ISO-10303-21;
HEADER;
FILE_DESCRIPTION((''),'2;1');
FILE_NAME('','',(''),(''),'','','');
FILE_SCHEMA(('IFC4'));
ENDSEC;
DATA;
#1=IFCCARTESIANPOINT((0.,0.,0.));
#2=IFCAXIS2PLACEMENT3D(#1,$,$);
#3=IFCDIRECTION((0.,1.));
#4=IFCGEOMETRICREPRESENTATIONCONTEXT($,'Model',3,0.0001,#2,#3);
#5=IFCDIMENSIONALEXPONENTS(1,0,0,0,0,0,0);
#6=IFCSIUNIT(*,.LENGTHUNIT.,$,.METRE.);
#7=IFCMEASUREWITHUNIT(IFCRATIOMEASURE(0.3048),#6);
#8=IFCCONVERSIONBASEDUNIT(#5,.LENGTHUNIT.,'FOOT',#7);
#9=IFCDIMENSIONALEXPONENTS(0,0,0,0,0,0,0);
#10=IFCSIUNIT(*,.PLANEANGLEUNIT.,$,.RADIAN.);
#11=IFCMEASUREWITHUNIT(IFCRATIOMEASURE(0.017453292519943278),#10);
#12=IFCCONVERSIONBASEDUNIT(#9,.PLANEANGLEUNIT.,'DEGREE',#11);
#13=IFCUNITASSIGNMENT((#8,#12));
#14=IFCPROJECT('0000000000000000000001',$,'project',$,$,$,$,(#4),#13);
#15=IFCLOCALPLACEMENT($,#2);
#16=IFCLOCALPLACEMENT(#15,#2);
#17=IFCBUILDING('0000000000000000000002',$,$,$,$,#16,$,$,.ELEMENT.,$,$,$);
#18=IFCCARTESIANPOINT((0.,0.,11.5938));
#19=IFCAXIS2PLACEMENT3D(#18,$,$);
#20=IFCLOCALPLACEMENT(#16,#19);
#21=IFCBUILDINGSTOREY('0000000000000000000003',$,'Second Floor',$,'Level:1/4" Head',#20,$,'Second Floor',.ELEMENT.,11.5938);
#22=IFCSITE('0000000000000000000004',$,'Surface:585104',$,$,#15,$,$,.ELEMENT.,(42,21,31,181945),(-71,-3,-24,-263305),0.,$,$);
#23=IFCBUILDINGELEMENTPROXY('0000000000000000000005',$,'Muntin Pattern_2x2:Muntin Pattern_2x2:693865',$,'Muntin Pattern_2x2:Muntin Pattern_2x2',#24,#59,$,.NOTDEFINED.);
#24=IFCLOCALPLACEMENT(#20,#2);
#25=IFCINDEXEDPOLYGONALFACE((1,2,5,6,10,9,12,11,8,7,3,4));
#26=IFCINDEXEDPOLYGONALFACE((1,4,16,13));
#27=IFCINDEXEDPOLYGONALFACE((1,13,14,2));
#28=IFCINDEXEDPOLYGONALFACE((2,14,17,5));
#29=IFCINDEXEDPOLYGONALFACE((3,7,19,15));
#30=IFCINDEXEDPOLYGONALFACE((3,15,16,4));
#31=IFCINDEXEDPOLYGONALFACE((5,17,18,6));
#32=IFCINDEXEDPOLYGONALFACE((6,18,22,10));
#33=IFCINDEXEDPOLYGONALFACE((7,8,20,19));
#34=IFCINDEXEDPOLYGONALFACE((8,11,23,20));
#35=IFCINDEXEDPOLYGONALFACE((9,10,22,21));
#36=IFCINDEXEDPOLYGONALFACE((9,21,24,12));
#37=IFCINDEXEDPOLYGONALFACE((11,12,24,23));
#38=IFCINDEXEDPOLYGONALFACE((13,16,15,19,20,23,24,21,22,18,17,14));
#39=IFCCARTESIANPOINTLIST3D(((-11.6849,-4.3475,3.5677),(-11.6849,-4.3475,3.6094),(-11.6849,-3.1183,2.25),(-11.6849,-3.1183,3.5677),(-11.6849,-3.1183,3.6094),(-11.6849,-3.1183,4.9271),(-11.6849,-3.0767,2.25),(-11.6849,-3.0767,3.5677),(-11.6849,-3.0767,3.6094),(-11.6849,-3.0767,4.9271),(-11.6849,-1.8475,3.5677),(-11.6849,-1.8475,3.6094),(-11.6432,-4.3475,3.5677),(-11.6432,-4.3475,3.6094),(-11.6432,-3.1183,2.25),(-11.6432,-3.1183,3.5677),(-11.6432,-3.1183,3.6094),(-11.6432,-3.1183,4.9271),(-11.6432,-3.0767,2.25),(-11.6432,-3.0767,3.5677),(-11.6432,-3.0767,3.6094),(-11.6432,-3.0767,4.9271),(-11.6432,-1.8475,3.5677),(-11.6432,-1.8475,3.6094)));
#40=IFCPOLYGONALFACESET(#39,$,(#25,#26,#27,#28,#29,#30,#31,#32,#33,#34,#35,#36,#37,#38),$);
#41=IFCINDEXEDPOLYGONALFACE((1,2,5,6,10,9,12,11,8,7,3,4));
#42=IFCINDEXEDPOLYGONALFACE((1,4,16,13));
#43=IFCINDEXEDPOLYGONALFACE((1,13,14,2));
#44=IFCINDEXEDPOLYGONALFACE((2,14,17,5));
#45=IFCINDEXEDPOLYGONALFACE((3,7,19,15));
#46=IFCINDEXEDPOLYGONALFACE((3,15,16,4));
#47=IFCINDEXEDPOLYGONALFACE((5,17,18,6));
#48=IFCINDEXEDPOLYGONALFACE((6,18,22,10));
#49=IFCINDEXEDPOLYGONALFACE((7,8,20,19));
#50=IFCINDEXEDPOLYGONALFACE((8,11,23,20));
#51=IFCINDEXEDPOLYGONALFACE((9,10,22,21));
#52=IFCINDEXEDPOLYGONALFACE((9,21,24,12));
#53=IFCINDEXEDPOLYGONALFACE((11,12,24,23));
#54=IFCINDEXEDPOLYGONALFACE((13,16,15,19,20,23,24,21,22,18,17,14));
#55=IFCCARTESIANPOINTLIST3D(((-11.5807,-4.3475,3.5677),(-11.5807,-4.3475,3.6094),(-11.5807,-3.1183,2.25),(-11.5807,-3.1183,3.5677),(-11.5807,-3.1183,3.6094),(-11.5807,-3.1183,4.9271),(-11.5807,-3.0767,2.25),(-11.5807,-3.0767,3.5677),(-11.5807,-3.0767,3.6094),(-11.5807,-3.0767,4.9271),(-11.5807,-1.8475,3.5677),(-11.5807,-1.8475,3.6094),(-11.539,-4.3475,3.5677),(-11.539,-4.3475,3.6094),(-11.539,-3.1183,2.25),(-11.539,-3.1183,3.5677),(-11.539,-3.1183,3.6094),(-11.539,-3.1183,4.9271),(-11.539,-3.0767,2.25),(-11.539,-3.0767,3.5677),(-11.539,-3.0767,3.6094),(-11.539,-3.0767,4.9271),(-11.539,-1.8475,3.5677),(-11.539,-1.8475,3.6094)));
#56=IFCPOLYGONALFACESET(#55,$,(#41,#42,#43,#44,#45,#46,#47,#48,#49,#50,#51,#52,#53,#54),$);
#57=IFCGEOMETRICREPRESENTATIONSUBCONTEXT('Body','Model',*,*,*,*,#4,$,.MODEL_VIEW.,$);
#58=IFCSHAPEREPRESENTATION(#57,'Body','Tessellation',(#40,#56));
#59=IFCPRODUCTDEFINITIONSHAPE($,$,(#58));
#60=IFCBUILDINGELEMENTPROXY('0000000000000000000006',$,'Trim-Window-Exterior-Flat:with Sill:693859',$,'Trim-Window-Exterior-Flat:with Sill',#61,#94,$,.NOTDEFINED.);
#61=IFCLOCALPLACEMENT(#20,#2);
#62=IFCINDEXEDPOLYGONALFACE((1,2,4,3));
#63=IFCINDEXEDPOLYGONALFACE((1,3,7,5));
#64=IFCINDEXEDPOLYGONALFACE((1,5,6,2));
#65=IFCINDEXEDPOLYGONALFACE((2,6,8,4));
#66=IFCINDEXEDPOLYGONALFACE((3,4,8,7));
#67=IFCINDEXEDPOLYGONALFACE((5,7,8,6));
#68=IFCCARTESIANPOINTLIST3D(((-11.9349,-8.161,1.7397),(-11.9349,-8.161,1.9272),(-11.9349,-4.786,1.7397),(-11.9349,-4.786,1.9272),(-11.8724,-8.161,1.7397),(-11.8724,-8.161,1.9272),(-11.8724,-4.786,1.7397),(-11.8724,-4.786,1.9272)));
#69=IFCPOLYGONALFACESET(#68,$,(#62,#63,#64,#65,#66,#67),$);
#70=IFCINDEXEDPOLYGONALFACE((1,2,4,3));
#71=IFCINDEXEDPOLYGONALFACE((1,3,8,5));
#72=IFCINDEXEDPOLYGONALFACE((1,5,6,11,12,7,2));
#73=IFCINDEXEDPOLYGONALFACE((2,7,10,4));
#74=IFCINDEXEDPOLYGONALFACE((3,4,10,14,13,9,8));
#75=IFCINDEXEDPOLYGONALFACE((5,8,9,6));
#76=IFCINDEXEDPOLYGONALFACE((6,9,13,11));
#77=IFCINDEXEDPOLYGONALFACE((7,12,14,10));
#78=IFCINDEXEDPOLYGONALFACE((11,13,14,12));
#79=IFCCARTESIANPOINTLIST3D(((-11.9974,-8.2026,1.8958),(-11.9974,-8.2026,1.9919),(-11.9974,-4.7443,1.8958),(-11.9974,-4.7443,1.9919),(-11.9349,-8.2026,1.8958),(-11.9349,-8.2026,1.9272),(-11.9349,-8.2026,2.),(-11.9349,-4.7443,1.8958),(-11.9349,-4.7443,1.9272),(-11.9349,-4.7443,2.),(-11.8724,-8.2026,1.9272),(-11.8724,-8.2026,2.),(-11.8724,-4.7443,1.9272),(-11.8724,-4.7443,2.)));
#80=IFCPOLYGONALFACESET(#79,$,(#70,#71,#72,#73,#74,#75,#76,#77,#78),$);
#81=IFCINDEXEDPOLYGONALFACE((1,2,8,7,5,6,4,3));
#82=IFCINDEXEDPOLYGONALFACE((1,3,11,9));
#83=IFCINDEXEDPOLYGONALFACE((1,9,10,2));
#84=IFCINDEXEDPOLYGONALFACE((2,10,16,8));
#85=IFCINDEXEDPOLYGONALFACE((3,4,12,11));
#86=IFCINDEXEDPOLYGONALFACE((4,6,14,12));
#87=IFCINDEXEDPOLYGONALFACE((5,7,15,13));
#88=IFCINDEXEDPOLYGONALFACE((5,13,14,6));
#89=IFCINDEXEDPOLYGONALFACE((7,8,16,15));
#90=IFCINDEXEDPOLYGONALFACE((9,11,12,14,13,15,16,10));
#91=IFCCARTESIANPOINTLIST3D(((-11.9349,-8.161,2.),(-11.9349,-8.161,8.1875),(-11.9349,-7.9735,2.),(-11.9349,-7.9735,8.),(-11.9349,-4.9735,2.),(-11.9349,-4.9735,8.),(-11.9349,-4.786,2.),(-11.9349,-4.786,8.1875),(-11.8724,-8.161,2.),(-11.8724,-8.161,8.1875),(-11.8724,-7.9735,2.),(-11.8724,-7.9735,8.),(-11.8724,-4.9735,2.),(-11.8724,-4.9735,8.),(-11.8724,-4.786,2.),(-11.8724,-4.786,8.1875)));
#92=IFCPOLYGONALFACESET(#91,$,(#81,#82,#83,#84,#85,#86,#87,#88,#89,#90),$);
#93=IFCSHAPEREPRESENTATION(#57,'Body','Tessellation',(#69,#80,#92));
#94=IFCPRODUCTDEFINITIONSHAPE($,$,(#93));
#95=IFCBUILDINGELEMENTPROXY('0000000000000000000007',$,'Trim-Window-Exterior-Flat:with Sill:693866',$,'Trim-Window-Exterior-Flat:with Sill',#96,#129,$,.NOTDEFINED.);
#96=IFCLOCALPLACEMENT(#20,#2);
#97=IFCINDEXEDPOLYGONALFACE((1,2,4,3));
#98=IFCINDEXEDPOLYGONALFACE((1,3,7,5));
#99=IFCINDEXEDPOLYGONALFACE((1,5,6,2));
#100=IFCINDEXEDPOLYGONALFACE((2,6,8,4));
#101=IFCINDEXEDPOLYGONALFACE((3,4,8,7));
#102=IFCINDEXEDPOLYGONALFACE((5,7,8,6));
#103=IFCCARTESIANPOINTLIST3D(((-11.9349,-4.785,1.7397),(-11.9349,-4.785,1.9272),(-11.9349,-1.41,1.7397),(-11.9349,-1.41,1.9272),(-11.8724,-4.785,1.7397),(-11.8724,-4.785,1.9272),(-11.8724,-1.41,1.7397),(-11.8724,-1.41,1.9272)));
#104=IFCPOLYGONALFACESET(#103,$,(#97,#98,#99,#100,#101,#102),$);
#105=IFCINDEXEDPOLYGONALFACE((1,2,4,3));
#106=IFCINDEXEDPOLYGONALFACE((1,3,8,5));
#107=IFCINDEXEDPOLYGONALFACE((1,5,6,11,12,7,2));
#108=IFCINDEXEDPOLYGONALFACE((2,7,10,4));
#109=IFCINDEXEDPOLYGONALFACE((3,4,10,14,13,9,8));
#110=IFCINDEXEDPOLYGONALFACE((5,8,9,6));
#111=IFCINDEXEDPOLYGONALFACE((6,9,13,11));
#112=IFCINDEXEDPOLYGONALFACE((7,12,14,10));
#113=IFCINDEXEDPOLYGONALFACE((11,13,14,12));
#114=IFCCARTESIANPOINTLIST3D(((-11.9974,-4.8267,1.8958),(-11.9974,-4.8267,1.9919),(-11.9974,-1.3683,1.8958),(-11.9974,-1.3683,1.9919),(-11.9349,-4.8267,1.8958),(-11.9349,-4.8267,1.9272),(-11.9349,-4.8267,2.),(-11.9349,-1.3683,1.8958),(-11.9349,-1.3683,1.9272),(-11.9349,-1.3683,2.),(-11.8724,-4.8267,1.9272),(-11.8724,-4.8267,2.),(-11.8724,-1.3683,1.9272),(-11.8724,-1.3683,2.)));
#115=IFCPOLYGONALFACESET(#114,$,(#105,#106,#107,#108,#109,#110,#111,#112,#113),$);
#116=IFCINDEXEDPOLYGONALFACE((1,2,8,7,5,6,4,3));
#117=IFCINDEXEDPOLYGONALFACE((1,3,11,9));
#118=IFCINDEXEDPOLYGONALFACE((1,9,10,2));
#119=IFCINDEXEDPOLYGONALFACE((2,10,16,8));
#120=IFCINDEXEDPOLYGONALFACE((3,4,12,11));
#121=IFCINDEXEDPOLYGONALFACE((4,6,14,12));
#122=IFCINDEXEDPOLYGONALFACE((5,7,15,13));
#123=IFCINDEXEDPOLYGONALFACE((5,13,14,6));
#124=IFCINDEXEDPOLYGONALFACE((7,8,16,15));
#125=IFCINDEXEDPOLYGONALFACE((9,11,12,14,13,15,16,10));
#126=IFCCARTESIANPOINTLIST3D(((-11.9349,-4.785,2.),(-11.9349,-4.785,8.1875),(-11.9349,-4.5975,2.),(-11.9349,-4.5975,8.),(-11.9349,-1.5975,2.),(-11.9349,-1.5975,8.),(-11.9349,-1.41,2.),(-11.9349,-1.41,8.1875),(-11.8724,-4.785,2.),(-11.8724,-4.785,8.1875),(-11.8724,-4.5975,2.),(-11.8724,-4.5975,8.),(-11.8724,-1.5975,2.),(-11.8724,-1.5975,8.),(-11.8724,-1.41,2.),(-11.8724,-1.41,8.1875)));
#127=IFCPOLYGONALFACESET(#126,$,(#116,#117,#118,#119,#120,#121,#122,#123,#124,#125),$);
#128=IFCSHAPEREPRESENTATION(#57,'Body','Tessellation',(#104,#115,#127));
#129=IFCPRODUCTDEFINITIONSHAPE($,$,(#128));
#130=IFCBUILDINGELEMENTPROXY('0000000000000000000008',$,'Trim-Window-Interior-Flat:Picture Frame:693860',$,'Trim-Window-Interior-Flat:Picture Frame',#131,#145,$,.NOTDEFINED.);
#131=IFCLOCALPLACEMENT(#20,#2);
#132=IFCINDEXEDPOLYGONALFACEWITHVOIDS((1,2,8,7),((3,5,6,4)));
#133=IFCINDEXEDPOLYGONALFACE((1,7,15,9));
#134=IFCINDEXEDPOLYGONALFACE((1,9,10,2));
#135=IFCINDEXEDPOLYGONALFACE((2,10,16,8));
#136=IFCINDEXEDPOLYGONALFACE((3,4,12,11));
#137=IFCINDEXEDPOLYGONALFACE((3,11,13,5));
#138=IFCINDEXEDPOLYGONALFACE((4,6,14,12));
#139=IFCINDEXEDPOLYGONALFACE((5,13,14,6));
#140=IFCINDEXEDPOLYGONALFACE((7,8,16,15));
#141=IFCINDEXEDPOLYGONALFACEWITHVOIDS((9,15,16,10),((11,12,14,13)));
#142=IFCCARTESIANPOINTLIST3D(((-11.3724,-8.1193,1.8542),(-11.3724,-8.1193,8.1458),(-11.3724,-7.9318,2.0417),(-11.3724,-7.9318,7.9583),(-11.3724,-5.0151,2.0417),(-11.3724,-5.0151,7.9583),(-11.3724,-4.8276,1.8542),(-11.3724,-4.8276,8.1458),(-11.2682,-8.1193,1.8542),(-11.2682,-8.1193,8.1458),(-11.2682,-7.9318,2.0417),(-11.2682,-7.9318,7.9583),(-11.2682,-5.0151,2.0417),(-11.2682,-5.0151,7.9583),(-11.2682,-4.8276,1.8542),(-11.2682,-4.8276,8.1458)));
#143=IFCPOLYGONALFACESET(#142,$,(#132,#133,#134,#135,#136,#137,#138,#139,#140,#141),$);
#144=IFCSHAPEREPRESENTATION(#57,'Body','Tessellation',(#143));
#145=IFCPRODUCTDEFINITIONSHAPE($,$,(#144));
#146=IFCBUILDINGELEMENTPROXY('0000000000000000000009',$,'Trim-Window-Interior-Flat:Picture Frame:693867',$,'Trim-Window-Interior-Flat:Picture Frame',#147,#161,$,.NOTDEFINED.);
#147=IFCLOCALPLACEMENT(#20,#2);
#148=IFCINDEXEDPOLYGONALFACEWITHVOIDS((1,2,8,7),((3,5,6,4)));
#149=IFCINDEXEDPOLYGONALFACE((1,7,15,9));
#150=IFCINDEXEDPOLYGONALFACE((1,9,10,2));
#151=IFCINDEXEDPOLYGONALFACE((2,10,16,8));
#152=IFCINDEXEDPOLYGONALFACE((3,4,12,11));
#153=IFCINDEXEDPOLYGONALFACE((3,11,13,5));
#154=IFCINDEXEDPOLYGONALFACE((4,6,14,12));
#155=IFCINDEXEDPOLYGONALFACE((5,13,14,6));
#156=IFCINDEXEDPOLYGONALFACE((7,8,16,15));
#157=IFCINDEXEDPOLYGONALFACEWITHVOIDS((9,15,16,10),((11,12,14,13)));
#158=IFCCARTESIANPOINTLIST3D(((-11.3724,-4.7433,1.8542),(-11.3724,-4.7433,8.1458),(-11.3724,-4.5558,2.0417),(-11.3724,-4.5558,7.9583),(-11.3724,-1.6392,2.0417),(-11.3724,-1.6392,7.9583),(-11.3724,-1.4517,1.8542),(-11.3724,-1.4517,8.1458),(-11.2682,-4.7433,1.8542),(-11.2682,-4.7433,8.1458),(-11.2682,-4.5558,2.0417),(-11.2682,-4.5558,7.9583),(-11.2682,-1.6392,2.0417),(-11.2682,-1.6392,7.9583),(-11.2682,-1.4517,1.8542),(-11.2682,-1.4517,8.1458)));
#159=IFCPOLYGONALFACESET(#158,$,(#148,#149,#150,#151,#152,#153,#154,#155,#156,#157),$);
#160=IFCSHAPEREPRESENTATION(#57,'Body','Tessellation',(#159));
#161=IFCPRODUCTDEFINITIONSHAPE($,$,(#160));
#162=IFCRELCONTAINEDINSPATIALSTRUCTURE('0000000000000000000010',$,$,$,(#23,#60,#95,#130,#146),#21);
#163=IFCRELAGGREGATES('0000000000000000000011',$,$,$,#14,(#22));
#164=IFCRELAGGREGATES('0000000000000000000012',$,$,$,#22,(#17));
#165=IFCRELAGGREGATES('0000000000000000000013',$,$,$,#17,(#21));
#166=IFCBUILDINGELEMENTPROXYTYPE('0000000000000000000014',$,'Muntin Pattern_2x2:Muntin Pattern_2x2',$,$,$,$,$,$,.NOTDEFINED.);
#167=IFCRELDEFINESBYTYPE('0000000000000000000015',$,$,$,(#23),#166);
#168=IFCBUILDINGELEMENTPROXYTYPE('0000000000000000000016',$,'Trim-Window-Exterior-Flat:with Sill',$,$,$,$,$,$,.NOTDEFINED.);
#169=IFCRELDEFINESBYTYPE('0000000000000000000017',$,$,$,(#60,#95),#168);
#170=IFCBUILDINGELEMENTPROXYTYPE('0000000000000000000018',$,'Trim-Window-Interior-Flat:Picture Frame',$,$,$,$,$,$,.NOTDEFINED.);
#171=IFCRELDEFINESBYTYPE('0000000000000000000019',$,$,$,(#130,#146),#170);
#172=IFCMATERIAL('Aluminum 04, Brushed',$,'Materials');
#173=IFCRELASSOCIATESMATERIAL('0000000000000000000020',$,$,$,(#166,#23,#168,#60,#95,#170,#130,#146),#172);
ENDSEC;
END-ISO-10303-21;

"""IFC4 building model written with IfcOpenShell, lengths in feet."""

from ifc_helpers import new_model, entity, si_unit, converted_unit, direction, frame, origin, place, context, subcontext, project, spatial, indexed_curve, outline, extrude, source, transform, mapped, material, type_object, type_shapes, element, save


model = new_model("IFC4")

# Units and contexts
model_context = context("Model", 3, precision=0.0001, world=origin(), true_north=direction((0.0, 1.0)))
body_context = subcontext(model_context, "Body", "Model", "MODEL_VIEW")
ifc_project = project(units=[converted_unit("LENGTHUNIT", "FOOT", entity("IfcRatioMeasure", 0.3048), si_unit("LENGTHUNIT", "METRE"), dimensions=[1, 0, 0, 0, 0, 0, 0]), converted_unit("PLANEANGLEUNIT", "DEGREE", entity("IfcRatioMeasure", 0.017453292519943278), si_unit("PLANEANGLEUNIT", "RADIAN"), dimensions=[0, 0, 0, 0, 0, 0, 0])], contexts=[model_context])

# Site, building, storey
site_placement = place(None, origin())
site = spatial("IfcSite", under=ifc_project, at=site_placement, Name="Surface:585104", CompositionType="ELEMENT", RefLatitude=(42, 21, 31, 181945), RefLongitude=(-71, -3, -24, -263305), RefElevation=0.0)
building_placement = place(site_placement, origin())
building = spatial("IfcBuilding", under=site, at=building_placement, CompositionType="ELEMENT")
storey_placement = place(building_placement, frame((0.0, 0.0, 11.5938)))
storey = spatial("IfcBuildingStorey", under=building, at=storey_placement, Name="Second Floor", ObjectType="Level:1/4\" Head", LongName="Second Floor", CompositionType="ELEMENT", Elevation=11.5938)

# Shared definitions
ifc_material_1 = material(Name="Aluminum 04, Brushed", Category="Materials")

# Building element proxies
building_element_proxy_type_1 = type_object("IfcBuildingElementProxyType", Name="Muntin Pattern_2x2:Muntin Pattern_2x2", PredefinedType="NOTDEFINED", material=ifc_material_1)
shared_shape_1 = source(origin(), body_context, "Body", "SweptSolid", [
    extrude(outline(indexed_curve([(0.0208, -0.0208), (1.3385, -0.0208), (1.3385, 0.0208), (0.0208, 0.0208), (0.0208, 1.25), (-0.0208, 1.25), (-0.0208, 0.0208), (-1.3385, 0.0208), (-1.3385, -0.0208), (-0.0208, -0.0208), (-0.0208, -1.25), (0.0208, -1.25), (0.0208, -0.0208)], self_intersect=False)), frame((0.0, 0.0312, 1.3385), z_axis=(0.0, 1.0, 0.0), x_axis=(0.0, 0.0, 1.0)), (0.0, 0.0, 1.0), 0.0417),
    extrude(outline(indexed_curve([(0.0208, -0.0208), (1.3385, -0.0208), (1.3385, 0.0208), (0.0208, 0.0208), (0.0208, 1.25), (-0.0208, 1.25), (-0.0208, 0.0208), (-1.3385, 0.0208), (-1.3385, -0.0208), (-0.0208, -0.0208), (-0.0208, -1.25), (0.0208, -1.25), (0.0208, -0.0208)], self_intersect=False)), frame((0.0, -0.0729, 1.3385), z_axis=(0.0, 1.0, 0.0), x_axis=(0.0, 0.0, 1.0)), (0.0, 0.0, 1.0), 0.0417),
])
type_shapes(building_element_proxy_type_1, [shared_shape_1])
for number, where, z_axis, x_axis, name in (
    (1, (-11.612, -3.0975, 2.25), (0.0, 0.0, 1.0), (0.0, 1.0, 0.0), "Muntin Pattern_2x2:Muntin Pattern_2x2:693865"),
):
    element("IfcBuildingElementProxy", number, at=place(storey_placement, frame(where, z_axis=z_axis, x_axis=x_axis)), inside=storey, type_object=building_element_proxy_type_1, material=ifc_material_1, Name=name, ObjectType="Muntin Pattern_2x2:Muntin Pattern_2x2", PredefinedType="NOTDEFINED", context=body_context, shape_type="MappedRepresentation", body=[
        mapped(shared_shape_1, transform((0.0, 0.0, 0.0), scale=1.0)),
    ])
building_element_proxy_type_2 = type_object("IfcBuildingElementProxyType", Name="Trim-Window-Exterior-Flat:with Sill", PredefinedType="NOTDEFINED", material=ifc_material_1)
shared_shape_2 = source(origin(), body_context, "Body", "SweptSolid", [
    extrude(outline(indexed_curve([(-1.6875, -0.0938), (1.6875, -0.0938), (1.6875, 0.0938), (-1.6875, 0.0938), (-1.6875, -0.0938)], self_intersect=False)), frame((0.0, -6.1665, 0.0), z_axis=(0.0, 0.0, 1.0), x_axis=(-1.0, 0.0, 0.0)), (0.0, 0.0, 1.0), 0.0625),
    extrude(outline(indexed_curve([(-0.0625, -0.0525), (0.0, -0.0525), (0.0, -0.0211), (0.0625, -0.0211), (0.0625, 0.0517), (0.0, 0.0517), (-0.0625, 0.0436), (-0.0625, -0.0525)], self_intersect=False)), frame((-1.7292, -6.0517, 0.0625), z_axis=(1.0, 0.0, 0.0), x_axis=(0.0, 0.0, -1.0)), (0.0, 0.0, 1.0), 3.4583),
    extrude(outline(indexed_curve([(-3.1406, -1.6875), (3.0469, -1.6875), (3.0469, -1.5), (-2.9531, -1.5), (-2.9531, 1.5), (3.0469, 1.5), (3.0469, 1.6875), (-3.1406, 1.6875), (-3.1406, -1.6875)], self_intersect=False)), frame((0.0, -2.9531, 0.0), z_axis=(0.0, 0.0, 1.0), x_axis=(0.0, -1.0, 0.0)), (0.0, 0.0, 1.0), 0.0625),
])
type_shapes(building_element_proxy_type_2, [shared_shape_2])
for number, where, z_axis, x_axis, name in (
    (2, (-11.8724, -6.4735, 8.0), (-1.0, 0.0, 0.0), (0.0, -1.0, 0.0), "Trim-Window-Exterior-Flat:with Sill:693859"),
    (3, (-11.8724, -3.0975, 8.0), (-1.0, 0.0, 0.0), (0.0, -1.0, 0.0), "Trim-Window-Exterior-Flat:with Sill:693866"),
):
    element("IfcBuildingElementProxy", number, at=place(storey_placement, frame(where, z_axis=z_axis, x_axis=x_axis)), inside=storey, type_object=building_element_proxy_type_2, material=ifc_material_1, Name=name, ObjectType="Trim-Window-Exterior-Flat:with Sill", PredefinedType="NOTDEFINED", context=body_context, shape_type="MappedRepresentation", body=[
        mapped(shared_shape_2, transform((0.0, 0.0, 0.0), scale=1.0)),
    ])
building_element_proxy_type_3 = type_object("IfcBuildingElementProxyType", Name="Trim-Window-Interior-Flat:Picture Frame", PredefinedType="NOTDEFINED", material=ifc_material_1)
shared_shape_3 = source(origin(), body_context, "Body", "SweptSolid", [
    extrude(outline(indexed_curve([(-1.6458, -3.1458), (1.6458, -3.1458), (1.6458, 3.1458), (-1.6458, 3.1458), (-1.6458, -3.1458)], self_intersect=False), holes=[indexed_curve([(-1.4583, -2.9583), (-1.4583, 2.9583), (1.4583, 2.9583), (1.4583, -2.9583), (-1.4583, -2.9583)], self_intersect=False)]), frame((0.0, -3.0, 0.0), z_axis=(0.0, 0.0, 1.0), x_axis=(-1.0, 0.0, 0.0)), (0.0, 0.0, 1.0), 0.1042),
])
type_shapes(building_element_proxy_type_3, [shared_shape_3])
for number, where, z_axis, x_axis, name in (
    (4, (-11.3724, -6.4735, 8.0), (1.0, 0.0, 0.0), (0.0, 1.0, 0.0), "Trim-Window-Interior-Flat:Picture Frame:693860"),
    (5, (-11.3724, -3.0975, 8.0), (1.0, 0.0, 0.0), (0.0, 1.0, 0.0), "Trim-Window-Interior-Flat:Picture Frame:693867"),
):
    element("IfcBuildingElementProxy", number, at=place(storey_placement, frame(where, z_axis=z_axis, x_axis=x_axis)), inside=storey, type_object=building_element_proxy_type_3, material=ifc_material_1, Name=name, ObjectType="Trim-Window-Interior-Flat:Picture Frame", PredefinedType="NOTDEFINED", context=body_context, shape_type="MappedRepresentation", body=[
        mapped(shared_shape_3, transform((0.0, 0.0, 0.0), scale=1.0)),
    ])

save(model, "model.ifc")
